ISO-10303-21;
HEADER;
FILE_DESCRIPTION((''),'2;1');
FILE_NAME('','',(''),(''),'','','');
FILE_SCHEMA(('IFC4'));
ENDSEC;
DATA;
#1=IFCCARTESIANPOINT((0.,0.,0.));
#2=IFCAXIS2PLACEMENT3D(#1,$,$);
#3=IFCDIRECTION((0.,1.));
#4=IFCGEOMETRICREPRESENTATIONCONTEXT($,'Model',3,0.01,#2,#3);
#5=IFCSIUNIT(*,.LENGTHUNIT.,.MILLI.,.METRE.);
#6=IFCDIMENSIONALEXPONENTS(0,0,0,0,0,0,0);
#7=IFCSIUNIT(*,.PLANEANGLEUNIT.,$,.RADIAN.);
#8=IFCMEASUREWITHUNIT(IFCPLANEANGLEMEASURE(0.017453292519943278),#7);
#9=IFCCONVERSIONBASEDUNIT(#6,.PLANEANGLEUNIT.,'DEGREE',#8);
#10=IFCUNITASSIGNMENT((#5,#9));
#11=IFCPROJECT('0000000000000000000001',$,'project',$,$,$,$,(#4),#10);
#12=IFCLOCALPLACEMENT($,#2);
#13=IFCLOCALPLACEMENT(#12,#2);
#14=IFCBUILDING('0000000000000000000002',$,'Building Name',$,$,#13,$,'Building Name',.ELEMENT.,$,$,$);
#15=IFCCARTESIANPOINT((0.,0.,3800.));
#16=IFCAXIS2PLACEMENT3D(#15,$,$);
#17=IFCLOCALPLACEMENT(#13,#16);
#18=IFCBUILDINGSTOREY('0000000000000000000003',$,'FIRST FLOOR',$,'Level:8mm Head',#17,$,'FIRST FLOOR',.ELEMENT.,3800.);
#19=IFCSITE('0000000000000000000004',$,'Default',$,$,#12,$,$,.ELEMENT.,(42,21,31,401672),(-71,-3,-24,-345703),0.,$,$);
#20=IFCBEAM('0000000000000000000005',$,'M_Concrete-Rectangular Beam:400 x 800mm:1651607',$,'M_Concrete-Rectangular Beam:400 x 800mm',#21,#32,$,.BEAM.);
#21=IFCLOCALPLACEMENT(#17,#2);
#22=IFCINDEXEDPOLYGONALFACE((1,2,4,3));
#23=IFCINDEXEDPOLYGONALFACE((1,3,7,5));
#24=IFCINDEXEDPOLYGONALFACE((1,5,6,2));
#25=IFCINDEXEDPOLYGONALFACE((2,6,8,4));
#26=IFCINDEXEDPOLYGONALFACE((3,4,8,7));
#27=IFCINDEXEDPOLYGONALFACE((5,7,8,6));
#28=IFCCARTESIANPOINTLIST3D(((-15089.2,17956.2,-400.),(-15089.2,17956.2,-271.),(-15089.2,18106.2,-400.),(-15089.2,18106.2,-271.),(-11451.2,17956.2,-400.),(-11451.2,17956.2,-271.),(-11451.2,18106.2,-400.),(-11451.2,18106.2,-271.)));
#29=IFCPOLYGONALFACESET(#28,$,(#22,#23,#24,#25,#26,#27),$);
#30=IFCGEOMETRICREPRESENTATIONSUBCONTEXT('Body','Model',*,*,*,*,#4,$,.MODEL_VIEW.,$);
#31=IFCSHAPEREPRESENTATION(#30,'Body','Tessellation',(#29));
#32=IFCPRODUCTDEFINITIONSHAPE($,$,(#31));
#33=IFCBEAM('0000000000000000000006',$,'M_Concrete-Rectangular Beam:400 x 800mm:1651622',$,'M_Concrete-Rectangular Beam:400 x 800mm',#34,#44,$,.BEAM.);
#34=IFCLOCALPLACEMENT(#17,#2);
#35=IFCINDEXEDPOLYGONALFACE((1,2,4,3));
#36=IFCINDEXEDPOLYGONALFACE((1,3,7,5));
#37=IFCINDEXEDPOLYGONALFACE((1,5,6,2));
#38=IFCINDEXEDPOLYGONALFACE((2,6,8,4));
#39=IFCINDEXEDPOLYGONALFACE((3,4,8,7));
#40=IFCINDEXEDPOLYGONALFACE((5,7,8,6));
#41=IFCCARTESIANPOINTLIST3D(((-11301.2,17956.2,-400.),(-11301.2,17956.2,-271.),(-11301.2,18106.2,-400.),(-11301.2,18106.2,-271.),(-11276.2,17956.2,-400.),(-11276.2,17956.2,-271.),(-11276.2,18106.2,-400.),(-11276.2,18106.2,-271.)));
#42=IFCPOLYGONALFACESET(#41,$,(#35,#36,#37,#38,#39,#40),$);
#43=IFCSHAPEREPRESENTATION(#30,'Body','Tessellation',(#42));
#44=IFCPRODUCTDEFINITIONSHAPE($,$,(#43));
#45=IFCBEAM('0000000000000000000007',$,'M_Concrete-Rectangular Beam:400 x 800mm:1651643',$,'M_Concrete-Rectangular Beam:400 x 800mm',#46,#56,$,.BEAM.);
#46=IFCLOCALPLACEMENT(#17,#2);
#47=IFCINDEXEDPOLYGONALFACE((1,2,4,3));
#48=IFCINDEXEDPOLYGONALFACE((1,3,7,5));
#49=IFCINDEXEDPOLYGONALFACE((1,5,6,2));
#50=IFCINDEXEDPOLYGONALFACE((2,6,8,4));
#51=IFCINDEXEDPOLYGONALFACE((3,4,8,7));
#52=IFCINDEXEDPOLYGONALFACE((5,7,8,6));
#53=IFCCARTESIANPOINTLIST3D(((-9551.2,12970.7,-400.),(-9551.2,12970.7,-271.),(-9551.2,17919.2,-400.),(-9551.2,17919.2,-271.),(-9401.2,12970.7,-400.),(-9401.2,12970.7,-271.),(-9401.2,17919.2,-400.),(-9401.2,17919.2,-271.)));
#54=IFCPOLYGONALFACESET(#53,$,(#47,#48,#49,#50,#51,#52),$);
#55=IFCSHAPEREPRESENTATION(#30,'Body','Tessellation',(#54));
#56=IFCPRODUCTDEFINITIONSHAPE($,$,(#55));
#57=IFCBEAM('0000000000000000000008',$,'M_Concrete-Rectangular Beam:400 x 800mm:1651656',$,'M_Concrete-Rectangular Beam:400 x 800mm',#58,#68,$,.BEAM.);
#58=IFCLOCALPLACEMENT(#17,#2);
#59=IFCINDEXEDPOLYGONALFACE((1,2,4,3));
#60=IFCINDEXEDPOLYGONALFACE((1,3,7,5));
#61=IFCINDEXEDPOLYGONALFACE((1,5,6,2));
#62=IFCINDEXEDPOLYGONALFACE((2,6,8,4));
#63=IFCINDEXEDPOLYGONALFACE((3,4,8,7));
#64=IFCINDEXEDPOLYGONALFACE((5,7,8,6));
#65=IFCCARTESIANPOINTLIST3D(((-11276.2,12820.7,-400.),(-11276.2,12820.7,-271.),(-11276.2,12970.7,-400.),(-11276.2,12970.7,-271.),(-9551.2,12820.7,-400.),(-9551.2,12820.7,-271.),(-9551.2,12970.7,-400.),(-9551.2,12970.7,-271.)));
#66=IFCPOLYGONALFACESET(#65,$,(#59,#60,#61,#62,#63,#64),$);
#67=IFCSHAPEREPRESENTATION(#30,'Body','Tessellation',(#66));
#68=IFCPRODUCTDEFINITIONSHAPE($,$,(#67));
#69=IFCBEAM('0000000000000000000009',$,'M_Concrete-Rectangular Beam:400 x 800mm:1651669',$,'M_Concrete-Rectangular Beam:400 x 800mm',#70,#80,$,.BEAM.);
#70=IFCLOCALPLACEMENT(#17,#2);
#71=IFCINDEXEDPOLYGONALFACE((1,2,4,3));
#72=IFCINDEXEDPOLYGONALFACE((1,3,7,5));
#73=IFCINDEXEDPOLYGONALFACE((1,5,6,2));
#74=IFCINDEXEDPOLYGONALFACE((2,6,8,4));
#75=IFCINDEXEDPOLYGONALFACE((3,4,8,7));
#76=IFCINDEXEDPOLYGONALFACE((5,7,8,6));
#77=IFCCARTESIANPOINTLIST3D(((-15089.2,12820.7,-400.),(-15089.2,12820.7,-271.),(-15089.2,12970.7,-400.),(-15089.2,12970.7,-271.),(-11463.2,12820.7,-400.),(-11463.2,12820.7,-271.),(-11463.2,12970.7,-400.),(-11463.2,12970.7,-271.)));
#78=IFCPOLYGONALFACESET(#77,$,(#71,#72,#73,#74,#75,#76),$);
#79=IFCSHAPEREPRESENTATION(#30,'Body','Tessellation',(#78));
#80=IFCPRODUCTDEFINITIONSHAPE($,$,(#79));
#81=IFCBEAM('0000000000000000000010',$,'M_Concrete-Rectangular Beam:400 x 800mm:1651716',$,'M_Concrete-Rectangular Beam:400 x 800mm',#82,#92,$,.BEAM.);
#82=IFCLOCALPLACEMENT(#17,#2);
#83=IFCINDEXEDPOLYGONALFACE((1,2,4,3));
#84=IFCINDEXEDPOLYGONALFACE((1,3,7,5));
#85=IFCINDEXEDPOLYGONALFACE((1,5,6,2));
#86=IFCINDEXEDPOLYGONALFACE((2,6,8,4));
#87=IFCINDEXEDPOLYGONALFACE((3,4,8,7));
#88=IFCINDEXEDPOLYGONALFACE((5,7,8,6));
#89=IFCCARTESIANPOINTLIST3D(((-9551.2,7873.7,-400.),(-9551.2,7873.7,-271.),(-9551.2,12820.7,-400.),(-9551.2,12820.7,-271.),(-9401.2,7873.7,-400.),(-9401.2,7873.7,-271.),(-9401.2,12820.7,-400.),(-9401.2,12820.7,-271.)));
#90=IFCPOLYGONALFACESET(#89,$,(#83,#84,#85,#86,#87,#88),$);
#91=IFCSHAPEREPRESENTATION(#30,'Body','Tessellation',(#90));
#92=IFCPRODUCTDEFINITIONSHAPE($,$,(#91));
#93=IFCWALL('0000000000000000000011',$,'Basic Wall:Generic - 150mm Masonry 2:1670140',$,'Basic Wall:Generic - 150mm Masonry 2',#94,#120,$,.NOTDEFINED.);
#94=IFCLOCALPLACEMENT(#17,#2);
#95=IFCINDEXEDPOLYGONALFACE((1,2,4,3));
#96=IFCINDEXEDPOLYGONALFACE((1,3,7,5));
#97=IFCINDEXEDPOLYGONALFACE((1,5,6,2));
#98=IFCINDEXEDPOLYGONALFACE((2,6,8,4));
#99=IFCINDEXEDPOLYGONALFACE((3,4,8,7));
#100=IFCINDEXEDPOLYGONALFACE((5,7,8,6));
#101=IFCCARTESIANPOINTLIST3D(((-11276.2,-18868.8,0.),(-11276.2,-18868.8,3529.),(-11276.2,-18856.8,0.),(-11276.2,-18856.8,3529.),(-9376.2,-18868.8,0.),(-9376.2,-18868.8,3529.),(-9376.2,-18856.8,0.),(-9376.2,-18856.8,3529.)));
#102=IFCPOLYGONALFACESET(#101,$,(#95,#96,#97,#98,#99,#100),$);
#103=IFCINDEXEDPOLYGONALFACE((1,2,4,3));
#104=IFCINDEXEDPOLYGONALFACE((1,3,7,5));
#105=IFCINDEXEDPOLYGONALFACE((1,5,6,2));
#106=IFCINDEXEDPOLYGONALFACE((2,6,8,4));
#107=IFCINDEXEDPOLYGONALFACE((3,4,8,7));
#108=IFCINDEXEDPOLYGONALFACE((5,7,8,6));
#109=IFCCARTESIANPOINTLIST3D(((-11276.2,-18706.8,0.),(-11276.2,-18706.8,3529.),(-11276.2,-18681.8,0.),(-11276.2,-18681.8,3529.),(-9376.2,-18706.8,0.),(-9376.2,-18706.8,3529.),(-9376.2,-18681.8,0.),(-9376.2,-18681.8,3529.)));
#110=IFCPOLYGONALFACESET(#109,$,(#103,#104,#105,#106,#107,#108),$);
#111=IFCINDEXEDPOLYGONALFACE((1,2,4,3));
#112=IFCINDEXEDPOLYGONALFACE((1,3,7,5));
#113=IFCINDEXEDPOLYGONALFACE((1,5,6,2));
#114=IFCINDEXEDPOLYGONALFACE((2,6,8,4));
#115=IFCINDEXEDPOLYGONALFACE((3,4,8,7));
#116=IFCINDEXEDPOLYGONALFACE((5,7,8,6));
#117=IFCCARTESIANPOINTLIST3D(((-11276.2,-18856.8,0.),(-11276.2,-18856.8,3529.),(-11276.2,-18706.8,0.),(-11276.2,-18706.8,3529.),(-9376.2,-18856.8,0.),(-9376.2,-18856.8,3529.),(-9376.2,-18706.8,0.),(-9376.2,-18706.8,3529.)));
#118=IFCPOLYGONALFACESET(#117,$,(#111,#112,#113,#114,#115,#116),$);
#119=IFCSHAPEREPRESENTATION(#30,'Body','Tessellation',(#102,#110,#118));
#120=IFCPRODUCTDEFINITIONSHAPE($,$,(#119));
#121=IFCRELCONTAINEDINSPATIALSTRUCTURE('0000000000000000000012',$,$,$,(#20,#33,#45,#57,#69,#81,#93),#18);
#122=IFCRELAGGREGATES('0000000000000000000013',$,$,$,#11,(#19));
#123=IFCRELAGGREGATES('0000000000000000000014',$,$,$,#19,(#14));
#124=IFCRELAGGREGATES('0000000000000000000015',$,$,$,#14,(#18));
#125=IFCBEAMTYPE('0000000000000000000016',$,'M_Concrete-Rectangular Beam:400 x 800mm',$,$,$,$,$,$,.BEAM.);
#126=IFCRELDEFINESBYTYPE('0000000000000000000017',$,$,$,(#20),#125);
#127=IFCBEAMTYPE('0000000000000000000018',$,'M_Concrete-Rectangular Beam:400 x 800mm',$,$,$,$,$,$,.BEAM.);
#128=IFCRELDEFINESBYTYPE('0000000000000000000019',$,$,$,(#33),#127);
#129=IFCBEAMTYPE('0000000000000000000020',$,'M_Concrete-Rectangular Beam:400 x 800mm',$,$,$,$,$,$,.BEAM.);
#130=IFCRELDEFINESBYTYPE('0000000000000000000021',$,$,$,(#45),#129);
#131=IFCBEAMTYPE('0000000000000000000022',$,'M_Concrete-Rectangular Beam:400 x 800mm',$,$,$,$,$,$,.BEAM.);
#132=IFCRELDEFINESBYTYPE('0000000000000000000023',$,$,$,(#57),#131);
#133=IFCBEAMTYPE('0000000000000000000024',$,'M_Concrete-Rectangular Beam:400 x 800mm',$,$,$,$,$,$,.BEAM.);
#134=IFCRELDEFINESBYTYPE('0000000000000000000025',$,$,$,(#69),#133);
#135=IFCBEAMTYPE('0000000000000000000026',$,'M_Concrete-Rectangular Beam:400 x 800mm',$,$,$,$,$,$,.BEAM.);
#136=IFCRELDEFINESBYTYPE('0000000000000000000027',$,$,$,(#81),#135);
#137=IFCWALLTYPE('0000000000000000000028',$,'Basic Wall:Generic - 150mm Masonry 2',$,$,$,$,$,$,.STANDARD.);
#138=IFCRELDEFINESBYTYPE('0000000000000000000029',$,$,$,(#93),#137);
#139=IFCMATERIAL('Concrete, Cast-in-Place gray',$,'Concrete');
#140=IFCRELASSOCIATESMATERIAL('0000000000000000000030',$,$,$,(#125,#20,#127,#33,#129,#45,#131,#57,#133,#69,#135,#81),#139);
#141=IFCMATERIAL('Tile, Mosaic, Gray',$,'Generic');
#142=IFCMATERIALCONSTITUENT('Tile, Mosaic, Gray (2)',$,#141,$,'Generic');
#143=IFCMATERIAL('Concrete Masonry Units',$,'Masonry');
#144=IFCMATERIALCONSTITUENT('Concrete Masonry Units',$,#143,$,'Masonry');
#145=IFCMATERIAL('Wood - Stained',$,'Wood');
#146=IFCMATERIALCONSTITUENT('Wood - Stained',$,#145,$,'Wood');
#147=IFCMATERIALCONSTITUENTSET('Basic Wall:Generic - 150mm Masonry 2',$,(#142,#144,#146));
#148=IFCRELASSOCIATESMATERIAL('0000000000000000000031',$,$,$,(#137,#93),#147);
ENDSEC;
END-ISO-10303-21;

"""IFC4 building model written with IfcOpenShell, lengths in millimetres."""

from ifc_helpers import new_model, entity, si_unit, converted_unit, direction, frame, origin, place, context, subcontext, project, spatial, indexed_curve, outline, extrude, source, transform, mapped, material, constituent, constituent_set, type_object, type_shapes, element, save


model = new_model("IFC4")

# Units and contexts
model_context = context("Model", 3, precision=0.01, world=origin(), true_north=direction((0.0, 1.0)))
body_context = subcontext(model_context, "Body", "Model", "MODEL_VIEW")
ifc_project = project(units=[si_unit("LENGTHUNIT", "METRE", prefix="MILLI"), converted_unit("PLANEANGLEUNIT", "DEGREE", entity("IfcPlaneAngleMeasure", 0.017453292519943278), si_unit("PLANEANGLEUNIT", "RADIAN"), dimensions=[0, 0, 0, 0, 0, 0, 0])], contexts=[model_context])

# Site, building, storey
site_placement = place(None, origin())
site = spatial("IfcSite", under=ifc_project, at=site_placement, Name="Default", CompositionType="ELEMENT", RefLatitude=(42, 21, 31, 401672), RefLongitude=(-71, -3, -24, -345703), RefElevation=0.0)
building_placement = place(site_placement, origin())
building = spatial("IfcBuilding", under=site, at=building_placement, Name="Building Name", LongName="Building Name", CompositionType="ELEMENT")
storey_placement = place(building_placement, frame((0.0, 0.0, 3800.0)))
storey = spatial("IfcBuildingStorey", under=building, at=storey_placement, Name="FIRST FLOOR", ObjectType="Level:8mm Head", LongName="FIRST FLOOR", CompositionType="ELEMENT", Elevation=3800.0)

# Beams
ifc_material_1 = material(Name="Concrete, Cast-in-Place gray", Category="Concrete")
beam_type_1 = type_object("IfcBeamType", Name="M_Concrete-Rectangular Beam:400 x 800mm", PredefinedType="BEAM", material=ifc_material_1)
shared_shape_1 = source(origin(), body_context, "Body", "SweptSolid", [
    extrude(outline(indexed_curve([(-64.5, -75.0), (64.5, -75.0), (64.5, 75.0), (-64.5, 75.0), (-64.5, -75.0)], self_intersect=False)), frame((-15089.2, 18031.2, 3464.5), z_axis=(1.0, 0.0, 0.0), x_axis=(0.0, 0.0, -1.0)), (0.0, 0.0, 1.0), 3638.0),
])
type_shapes(beam_type_1, [shared_shape_1])
beam_1_placement = place(storey_placement, frame((0.0, 0.0, -3800.0)))
element("IfcBeam", 1, at=beam_1_placement, inside=storey, type_object=beam_type_1, material=ifc_material_1, Name="M_Concrete-Rectangular Beam:400 x 800mm:1651607", ObjectType="M_Concrete-Rectangular Beam:400 x 800mm", PredefinedType="BEAM", context=body_context, shape_type="MappedRepresentation", body=[
    mapped(shared_shape_1, transform((0.0, 0.0, 0.0), scale=1.0)),
])
beam_type_2 = type_object("IfcBeamType", Name="M_Concrete-Rectangular Beam:400 x 800mm", PredefinedType="BEAM", material=ifc_material_1)
shared_shape_2 = source(origin(), body_context, "Body", "SweptSolid", [
    extrude(outline(indexed_curve([(-64.5, -75.0), (64.5, -75.0), (64.5, 75.0), (-64.5, 75.0), (-64.5, -75.0)], self_intersect=False)), frame((-11301.2, 18031.2, 3464.5), z_axis=(1.0, 0.0, 0.0), x_axis=(0.0, 0.0, -1.0)), (0.0, 0.0, 1.0), 25.0),
])
type_shapes(beam_type_2, [shared_shape_2])
beam_2_placement = place(storey_placement, frame((0.0, 0.0, -3800.0)))
element("IfcBeam", 2, at=beam_2_placement, inside=storey, type_object=beam_type_2, material=ifc_material_1, Name="M_Concrete-Rectangular Beam:400 x 800mm:1651622", ObjectType="M_Concrete-Rectangular Beam:400 x 800mm", PredefinedType="BEAM", context=body_context, shape_type="MappedRepresentation", body=[
    mapped(shared_shape_2, transform((0.0, 0.0, 0.0), scale=1.0)),
])
beam_type_3 = type_object("IfcBeamType", Name="M_Concrete-Rectangular Beam:400 x 800mm", PredefinedType="BEAM", material=ifc_material_1)
shared_shape_3 = source(origin(), body_context, "Body", "SweptSolid", [
    extrude(outline(indexed_curve([(-75.0, -64.5), (75.0, -64.5), (75.0, 64.5), (-75.0, 64.5), (-75.0, -64.5)], self_intersect=False)), frame((-9476.2, 17919.2, 3464.5), z_axis=(0.0, -1.0, 0.0), x_axis=(-1.0, 0.0, 0.0)), (0.0, 0.0, 1.0), 4948.5),
])
type_shapes(beam_type_3, [shared_shape_3])
beam_3_placement = place(storey_placement, frame((0.0, 0.0, -3800.0)))
element("IfcBeam", 3, at=beam_3_placement, inside=storey, type_object=beam_type_3, material=ifc_material_1, Name="M_Concrete-Rectangular Beam:400 x 800mm:1651643", ObjectType="M_Concrete-Rectangular Beam:400 x 800mm", PredefinedType="BEAM", context=body_context, shape_type="MappedRepresentation", body=[
    mapped(shared_shape_3, transform((0.0, 0.0, 0.0), scale=1.0)),
])
beam_type_4 = type_object("IfcBeamType", Name="M_Concrete-Rectangular Beam:400 x 800mm", PredefinedType="BEAM", material=ifc_material_1)
shared_shape_4 = source(origin(), body_context, "Body", "SweptSolid", [
    extrude(outline(indexed_curve([(-64.5, -75.0), (64.5, -75.0), (64.5, 75.0), (-64.5, 75.0), (-64.5, -75.0)], self_intersect=False)), frame((-9551.2, 12895.7, 3464.5), z_axis=(-1.0, 0.0, 0.0), x_axis=(0.0, 0.0, -1.0)), (0.0, 0.0, 1.0), 1725.0),
])
type_shapes(beam_type_4, [shared_shape_4])
beam_4_placement = place(storey_placement, frame((0.0, 0.0, -3800.0)))
element("IfcBeam", 4, at=beam_4_placement, inside=storey, type_object=beam_type_4, material=ifc_material_1, Name="M_Concrete-Rectangular Beam:400 x 800mm:1651656", ObjectType="M_Concrete-Rectangular Beam:400 x 800mm", PredefinedType="BEAM", context=body_context, shape_type="MappedRepresentation", body=[
    mapped(shared_shape_4, transform((0.0, 0.0, 0.0), scale=1.0)),
])
beam_type_5 = type_object("IfcBeamType", Name="M_Concrete-Rectangular Beam:400 x 800mm", PredefinedType="BEAM", material=ifc_material_1)
shared_shape_5 = source(origin(), body_context, "Body", "SweptSolid", [
    extrude(outline(indexed_curve([(-64.5, -75.0), (64.5, -75.0), (64.5, 75.0), (-64.5, 75.0), (-64.5, -75.0)], self_intersect=False)), frame((-11463.2, 12895.7, 3464.5), z_axis=(-1.0, 0.0, 0.0), x_axis=(0.0, 0.0, -1.0)), (0.0, 0.0, 1.0), 3626.0),
])
type_shapes(beam_type_5, [shared_shape_5])
beam_5_placement = place(storey_placement, frame((0.0, 0.0, -3800.0)))
element("IfcBeam", 5, at=beam_5_placement, inside=storey, type_object=beam_type_5, material=ifc_material_1, Name="M_Concrete-Rectangular Beam:400 x 800mm:1651669", ObjectType="M_Concrete-Rectangular Beam:400 x 800mm", PredefinedType="BEAM", context=body_context, shape_type="MappedRepresentation", body=[
    mapped(shared_shape_5, transform((0.0, 0.0, 0.0), scale=1.0)),
])
beam_type_6 = type_object("IfcBeamType", Name="M_Concrete-Rectangular Beam:400 x 800mm", PredefinedType="BEAM", material=ifc_material_1)
shared_shape_6 = source(origin(), body_context, "Body", "SweptSolid", [
    extrude(outline(indexed_curve([(-75.0, -64.5), (75.0, -64.5), (75.0, 64.5), (-75.0, 64.5), (-75.0, -64.5)], self_intersect=False)), frame((-9476.2, 12820.7, 3464.5), z_axis=(0.0, -1.0, 0.0), x_axis=(-1.0, 0.0, 0.0)), (0.0, 0.0, 1.0), 4947.0),
])
type_shapes(beam_type_6, [shared_shape_6])
beam_6_placement = place(storey_placement, frame((0.0, 0.0, -3800.0)))
element("IfcBeam", 6, at=beam_6_placement, inside=storey, type_object=beam_type_6, material=ifc_material_1, Name="M_Concrete-Rectangular Beam:400 x 800mm:1651716", ObjectType="M_Concrete-Rectangular Beam:400 x 800mm", PredefinedType="BEAM", context=body_context, shape_type="MappedRepresentation", body=[
    mapped(shared_shape_6, transform((0.0, 0.0, 0.0), scale=1.0)),
])

# Wall
ifc_material_2 = material(Name="Tile, Mosaic, Gray", Category="Generic")
ifc_constituent_1 = constituent(ifc_material_2, Name="Tile, Mosaic, Gray (2)", Category="Generic")
ifc_material_3 = material(Name="Concrete Masonry Units", Category="Masonry")
ifc_constituent_2 = constituent(ifc_material_3, Name="Concrete Masonry Units", Category="Masonry")
ifc_material_4 = material(Name="Wood - Stained", Category="Wood")
ifc_constituent_3 = constituent(ifc_material_4, Name="Wood - Stained", Category="Wood")
ifc_constituent_set_1 = constituent_set(constituents=[ifc_constituent_1, ifc_constituent_2, ifc_constituent_3], Name="Basic Wall:Generic - 150mm Masonry 2")
wall_type_1 = type_object("IfcWallType", Name="Basic Wall:Generic - 150mm Masonry 2", PredefinedType="STANDARD", material=ifc_constituent_set_1)
wall_1_placement = place(storey_placement, frame((-11276.2, -18775.3, 0.0)))
element("IfcWall", 7, at=wall_1_placement, inside=storey, type_object=wall_type_1, material=ifc_constituent_set_1, Name="Basic Wall:Generic - 150mm Masonry 2:1670140", ObjectType="Basic Wall:Generic - 150mm Masonry 2", PredefinedType="NOTDEFINED", context=body_context, shape_type="SweptSolid", body=[
    extrude(outline(indexed_curve([(-6.0, -950.0), (6.0, -950.0), (6.0, 950.0), (-6.0, 950.0), (-6.0, -950.0)], self_intersect=False)), frame((950.0, -87.5, 0.0), z_axis=(0.0, 0.0, 1.0), x_axis=(0.0, 1.0, 0.0)), (0.0, 0.0, 1.0), 3529.0),
    extrude(outline(indexed_curve([(-12.5, -950.0), (12.5, -950.0), (12.5, 950.0), (-12.5, 950.0), (-12.5, -950.0)], self_intersect=False)), frame((950.0, 81.0, 0.0), z_axis=(0.0, 0.0, 1.0), x_axis=(0.0, -1.0, 0.0)), (0.0, 0.0, 1.0), 3529.0),
    extrude(outline(indexed_curve([(-950.0, -75.0), (950.0, -75.0), (950.0, 75.0), (-950.0, 75.0), (-950.0, -75.0)], self_intersect=False)), frame((950.0, -6.5, 0.0)), (0.0, 0.0, 1.0), 3529.0),
])

save(model, "model.ifc")
